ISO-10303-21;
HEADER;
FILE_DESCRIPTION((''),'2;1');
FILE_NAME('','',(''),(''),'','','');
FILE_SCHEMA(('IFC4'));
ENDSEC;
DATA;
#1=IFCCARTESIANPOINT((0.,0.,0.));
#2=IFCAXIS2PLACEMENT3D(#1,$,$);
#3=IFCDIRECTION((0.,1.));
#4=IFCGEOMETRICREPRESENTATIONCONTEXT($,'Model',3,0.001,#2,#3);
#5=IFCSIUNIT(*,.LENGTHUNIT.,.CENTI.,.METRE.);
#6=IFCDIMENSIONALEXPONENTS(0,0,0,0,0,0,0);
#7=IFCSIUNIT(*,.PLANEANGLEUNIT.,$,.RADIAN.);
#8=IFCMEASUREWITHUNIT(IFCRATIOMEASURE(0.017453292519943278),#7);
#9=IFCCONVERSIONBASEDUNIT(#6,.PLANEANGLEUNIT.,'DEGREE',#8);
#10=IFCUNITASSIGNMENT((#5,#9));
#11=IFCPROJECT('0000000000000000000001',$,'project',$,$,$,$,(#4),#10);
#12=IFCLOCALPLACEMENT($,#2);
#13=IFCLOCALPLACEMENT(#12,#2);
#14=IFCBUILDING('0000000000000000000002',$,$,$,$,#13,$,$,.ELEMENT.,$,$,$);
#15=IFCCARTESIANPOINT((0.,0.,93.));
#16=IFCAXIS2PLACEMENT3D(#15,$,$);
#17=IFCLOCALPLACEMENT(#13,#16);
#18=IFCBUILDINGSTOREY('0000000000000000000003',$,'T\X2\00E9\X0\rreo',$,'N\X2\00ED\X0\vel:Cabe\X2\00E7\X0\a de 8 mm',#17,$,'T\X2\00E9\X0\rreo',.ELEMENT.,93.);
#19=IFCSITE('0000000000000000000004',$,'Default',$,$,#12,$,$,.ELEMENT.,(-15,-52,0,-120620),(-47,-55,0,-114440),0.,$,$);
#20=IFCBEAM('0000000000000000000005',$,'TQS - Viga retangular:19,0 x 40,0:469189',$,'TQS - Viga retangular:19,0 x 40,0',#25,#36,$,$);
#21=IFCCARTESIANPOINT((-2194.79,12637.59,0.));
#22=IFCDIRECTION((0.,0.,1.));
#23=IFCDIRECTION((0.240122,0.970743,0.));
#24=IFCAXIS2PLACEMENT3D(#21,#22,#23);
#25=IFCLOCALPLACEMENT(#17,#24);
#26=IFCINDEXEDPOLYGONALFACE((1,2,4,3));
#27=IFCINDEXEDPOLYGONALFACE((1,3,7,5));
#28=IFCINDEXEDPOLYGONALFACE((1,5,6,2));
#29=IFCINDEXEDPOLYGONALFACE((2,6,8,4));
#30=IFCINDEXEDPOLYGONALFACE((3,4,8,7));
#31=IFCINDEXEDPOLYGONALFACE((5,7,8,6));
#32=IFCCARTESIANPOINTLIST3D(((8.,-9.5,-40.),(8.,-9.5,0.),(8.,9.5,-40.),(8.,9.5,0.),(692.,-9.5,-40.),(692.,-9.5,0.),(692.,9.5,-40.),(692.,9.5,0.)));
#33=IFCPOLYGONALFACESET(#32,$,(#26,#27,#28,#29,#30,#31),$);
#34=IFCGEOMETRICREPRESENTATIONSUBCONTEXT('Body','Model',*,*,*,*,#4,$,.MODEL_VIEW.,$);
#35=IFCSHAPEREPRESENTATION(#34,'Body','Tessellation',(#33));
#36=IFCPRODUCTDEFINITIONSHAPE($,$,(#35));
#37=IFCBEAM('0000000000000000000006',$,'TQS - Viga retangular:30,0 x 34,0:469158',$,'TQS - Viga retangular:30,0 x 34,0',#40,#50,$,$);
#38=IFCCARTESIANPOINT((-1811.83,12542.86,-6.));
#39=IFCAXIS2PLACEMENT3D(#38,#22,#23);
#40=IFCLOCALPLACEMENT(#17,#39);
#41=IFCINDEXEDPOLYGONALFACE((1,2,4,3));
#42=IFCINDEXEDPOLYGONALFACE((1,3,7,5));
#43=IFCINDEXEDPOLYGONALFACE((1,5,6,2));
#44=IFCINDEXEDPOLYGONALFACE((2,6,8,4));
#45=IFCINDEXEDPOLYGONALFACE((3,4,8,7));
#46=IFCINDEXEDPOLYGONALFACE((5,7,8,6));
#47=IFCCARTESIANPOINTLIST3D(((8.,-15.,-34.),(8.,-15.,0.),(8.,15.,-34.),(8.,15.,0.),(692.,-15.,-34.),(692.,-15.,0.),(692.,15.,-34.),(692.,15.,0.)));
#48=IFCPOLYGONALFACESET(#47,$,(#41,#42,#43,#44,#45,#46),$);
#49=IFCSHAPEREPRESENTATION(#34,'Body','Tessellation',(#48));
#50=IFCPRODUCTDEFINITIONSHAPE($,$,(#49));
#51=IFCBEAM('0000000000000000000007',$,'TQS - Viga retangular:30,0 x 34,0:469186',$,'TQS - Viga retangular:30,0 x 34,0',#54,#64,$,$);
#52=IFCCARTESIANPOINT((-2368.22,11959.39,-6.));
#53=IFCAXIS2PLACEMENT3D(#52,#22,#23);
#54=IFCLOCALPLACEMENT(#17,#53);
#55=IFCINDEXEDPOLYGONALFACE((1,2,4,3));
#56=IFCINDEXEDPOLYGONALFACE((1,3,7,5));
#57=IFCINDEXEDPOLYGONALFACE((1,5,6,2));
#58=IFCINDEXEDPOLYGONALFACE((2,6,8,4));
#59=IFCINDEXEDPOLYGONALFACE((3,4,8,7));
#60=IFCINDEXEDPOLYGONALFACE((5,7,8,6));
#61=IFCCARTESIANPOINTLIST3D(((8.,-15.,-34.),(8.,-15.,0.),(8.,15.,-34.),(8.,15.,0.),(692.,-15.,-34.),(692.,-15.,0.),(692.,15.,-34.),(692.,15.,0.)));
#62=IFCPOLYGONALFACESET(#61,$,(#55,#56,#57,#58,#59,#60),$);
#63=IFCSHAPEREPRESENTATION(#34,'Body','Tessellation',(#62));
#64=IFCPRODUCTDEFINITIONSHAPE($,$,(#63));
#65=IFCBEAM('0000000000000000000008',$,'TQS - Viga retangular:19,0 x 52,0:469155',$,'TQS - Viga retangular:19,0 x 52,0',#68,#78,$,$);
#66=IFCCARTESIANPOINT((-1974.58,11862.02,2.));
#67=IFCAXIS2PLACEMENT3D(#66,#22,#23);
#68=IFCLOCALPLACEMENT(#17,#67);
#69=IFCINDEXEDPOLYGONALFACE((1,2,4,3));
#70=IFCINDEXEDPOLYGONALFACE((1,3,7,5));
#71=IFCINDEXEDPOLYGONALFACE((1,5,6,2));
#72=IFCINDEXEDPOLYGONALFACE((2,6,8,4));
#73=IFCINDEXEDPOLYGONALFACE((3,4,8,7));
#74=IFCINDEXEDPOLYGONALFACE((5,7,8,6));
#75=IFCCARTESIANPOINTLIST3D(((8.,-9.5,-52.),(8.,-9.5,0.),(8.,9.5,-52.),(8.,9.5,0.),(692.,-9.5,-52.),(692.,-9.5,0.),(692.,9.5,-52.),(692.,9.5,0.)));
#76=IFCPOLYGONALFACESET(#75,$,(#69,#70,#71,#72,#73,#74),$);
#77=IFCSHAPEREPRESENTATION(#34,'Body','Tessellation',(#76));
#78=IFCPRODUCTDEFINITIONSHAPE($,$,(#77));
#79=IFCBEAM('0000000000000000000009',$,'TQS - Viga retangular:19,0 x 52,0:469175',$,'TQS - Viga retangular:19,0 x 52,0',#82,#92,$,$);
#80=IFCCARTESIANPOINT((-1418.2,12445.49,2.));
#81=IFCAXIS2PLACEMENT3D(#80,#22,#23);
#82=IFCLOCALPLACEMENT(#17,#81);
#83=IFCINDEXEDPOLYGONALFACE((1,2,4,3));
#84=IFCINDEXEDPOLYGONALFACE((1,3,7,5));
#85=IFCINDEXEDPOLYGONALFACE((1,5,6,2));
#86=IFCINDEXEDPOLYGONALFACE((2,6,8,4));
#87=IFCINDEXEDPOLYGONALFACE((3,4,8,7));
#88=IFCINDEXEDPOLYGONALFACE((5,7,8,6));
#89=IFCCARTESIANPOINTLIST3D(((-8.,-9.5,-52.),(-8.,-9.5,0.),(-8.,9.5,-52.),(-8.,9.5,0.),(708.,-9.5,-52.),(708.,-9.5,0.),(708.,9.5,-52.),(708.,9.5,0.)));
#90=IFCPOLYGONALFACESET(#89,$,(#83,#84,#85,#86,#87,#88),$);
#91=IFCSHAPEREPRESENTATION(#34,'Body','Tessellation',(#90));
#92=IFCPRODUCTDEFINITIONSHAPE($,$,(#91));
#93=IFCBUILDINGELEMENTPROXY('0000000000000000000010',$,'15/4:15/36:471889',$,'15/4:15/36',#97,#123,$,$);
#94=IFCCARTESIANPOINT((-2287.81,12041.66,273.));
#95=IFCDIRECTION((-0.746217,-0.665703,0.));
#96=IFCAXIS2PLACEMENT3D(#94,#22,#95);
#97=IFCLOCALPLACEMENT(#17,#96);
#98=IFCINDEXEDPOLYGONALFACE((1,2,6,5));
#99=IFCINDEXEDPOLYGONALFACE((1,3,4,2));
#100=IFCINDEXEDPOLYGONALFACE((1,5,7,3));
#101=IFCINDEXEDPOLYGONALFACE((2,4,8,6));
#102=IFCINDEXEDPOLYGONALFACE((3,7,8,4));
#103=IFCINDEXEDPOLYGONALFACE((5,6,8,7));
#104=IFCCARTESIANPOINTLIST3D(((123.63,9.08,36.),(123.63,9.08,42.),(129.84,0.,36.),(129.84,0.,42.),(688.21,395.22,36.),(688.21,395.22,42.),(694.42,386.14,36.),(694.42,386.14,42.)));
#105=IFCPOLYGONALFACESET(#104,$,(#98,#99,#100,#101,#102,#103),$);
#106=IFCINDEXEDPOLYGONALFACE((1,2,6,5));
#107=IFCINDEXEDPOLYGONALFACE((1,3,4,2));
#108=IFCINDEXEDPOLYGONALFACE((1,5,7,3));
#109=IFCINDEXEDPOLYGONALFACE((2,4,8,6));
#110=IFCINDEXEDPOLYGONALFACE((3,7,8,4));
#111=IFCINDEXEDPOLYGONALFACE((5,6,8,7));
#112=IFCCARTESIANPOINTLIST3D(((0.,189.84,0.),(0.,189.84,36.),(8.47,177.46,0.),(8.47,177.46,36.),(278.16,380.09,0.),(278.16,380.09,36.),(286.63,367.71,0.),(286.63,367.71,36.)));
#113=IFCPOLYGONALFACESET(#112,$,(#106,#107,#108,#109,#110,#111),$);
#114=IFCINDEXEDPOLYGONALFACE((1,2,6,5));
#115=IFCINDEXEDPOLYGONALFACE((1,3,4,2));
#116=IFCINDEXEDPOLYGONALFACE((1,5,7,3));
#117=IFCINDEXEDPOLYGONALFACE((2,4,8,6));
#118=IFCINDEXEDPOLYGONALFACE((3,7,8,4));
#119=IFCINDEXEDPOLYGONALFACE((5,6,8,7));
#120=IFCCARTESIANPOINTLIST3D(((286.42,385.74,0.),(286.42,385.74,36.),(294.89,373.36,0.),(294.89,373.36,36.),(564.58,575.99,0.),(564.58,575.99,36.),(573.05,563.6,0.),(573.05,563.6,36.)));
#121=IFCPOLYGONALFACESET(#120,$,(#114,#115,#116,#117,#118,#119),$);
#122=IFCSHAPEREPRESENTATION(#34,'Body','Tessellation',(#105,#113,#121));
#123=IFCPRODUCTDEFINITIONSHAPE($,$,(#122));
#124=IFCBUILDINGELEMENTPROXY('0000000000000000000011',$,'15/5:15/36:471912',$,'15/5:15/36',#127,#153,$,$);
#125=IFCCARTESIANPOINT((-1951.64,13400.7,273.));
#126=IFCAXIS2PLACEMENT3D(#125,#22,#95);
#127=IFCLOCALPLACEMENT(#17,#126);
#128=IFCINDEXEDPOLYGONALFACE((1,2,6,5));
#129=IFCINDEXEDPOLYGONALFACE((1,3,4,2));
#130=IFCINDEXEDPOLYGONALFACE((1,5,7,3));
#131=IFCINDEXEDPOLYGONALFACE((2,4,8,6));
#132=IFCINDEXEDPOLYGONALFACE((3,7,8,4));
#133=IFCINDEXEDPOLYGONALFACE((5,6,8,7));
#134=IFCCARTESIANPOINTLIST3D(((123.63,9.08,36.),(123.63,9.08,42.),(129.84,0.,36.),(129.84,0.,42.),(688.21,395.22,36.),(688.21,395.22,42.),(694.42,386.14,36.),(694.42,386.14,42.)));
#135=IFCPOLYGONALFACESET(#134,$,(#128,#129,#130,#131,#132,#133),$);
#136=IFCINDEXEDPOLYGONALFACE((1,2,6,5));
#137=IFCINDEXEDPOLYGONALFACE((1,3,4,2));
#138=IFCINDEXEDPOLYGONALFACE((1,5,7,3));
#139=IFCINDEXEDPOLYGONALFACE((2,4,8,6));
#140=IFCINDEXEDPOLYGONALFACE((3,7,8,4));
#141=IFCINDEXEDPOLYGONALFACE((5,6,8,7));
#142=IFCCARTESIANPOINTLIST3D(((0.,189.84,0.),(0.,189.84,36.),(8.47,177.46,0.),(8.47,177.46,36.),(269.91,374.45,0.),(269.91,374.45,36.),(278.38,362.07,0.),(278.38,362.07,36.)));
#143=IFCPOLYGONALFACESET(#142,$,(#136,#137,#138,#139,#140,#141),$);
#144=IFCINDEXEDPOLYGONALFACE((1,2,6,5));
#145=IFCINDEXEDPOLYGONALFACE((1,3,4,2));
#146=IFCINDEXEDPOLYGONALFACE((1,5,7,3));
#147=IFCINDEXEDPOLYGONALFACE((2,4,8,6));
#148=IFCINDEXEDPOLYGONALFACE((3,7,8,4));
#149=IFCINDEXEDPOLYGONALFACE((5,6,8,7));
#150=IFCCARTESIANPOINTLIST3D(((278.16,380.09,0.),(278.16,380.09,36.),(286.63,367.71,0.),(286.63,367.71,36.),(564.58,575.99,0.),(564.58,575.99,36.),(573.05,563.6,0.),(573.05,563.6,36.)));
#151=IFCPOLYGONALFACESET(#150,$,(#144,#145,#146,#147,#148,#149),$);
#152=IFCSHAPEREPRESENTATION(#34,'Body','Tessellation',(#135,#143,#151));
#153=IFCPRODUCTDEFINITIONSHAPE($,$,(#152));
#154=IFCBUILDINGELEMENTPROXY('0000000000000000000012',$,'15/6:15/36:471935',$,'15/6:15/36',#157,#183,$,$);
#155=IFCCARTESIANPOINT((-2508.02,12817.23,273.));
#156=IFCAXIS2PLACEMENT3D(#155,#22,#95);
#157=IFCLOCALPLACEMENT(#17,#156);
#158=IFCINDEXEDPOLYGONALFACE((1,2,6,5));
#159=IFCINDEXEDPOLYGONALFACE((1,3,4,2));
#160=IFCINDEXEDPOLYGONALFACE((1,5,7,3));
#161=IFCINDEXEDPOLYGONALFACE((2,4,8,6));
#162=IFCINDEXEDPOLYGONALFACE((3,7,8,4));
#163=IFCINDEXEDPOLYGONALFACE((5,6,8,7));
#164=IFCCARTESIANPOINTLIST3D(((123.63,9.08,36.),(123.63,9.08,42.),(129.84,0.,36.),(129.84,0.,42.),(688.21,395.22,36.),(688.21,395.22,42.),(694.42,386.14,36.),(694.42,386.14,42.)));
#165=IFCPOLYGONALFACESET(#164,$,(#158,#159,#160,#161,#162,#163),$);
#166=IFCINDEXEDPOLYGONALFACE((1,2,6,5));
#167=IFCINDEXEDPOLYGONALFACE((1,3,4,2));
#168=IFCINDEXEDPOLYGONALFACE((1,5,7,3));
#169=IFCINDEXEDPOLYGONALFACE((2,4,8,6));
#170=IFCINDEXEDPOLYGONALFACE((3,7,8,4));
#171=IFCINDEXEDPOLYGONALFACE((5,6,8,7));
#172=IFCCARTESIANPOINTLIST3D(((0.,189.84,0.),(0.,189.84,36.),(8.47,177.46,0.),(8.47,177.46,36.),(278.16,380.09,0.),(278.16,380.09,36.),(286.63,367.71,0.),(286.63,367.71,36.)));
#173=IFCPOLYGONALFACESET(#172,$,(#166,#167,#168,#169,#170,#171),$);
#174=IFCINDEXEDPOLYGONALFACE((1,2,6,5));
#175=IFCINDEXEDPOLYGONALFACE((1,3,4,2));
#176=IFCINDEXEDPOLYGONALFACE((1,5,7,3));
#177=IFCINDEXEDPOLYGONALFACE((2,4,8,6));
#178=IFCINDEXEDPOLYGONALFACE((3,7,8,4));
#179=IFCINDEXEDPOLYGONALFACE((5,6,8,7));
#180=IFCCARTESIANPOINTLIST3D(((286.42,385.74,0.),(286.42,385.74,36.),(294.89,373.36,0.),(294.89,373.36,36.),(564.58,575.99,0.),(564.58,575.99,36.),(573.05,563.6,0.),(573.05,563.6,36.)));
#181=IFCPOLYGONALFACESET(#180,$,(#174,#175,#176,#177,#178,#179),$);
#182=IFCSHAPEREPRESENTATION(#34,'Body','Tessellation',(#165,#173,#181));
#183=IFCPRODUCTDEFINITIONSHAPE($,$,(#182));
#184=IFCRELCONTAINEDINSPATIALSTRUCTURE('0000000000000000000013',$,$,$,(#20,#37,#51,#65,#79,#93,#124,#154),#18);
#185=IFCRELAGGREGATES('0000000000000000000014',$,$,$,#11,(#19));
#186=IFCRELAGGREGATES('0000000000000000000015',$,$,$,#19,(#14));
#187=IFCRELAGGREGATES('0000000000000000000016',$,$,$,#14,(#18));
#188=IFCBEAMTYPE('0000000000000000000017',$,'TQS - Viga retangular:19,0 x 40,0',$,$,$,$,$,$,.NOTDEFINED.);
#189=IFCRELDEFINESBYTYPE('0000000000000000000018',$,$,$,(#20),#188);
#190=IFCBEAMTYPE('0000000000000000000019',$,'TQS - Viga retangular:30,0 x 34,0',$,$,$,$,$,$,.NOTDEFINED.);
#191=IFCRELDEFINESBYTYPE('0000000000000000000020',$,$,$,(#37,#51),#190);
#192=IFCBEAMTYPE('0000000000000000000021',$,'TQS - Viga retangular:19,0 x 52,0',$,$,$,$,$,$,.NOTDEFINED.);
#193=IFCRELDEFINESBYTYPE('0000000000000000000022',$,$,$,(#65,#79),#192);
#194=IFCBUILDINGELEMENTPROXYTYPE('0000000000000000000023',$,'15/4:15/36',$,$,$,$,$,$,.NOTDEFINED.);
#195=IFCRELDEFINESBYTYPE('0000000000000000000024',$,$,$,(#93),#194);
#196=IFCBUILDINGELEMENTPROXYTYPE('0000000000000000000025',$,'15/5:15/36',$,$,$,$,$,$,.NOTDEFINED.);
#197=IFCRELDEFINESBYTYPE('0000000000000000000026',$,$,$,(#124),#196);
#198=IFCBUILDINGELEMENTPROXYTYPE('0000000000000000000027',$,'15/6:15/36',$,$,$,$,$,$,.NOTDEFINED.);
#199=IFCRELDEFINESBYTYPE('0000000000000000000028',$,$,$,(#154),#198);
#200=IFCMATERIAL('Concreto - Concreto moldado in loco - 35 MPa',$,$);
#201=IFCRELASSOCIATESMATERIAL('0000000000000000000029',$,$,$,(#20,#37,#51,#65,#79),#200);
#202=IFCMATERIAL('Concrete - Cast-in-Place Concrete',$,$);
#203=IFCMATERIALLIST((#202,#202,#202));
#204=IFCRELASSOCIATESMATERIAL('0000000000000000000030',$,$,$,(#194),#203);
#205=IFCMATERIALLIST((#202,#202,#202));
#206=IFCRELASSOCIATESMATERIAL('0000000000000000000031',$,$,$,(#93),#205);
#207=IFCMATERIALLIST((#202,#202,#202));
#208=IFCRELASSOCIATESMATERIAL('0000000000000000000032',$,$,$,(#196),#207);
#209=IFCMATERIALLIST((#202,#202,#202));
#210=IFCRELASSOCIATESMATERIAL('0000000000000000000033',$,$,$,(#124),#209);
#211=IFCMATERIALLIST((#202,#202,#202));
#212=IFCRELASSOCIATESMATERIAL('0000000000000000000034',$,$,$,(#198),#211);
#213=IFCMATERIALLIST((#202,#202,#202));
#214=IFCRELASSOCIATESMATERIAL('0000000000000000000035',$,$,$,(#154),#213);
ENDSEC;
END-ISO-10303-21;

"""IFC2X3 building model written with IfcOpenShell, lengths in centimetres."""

from ifc_helpers import new_model, entity, si_unit, converted_unit, direction, frame, frame_2d, origin, origin_2d_with_axis, place, context, subcontext, project, spatial, rectangle, extrude, source, transform, mapped, material, material_list, type_object, type_shapes, element, save


model = new_model("IFC2X3")

# Units and contexts
model_context = context("Model", 3, precision=0.001, world=origin(), true_north=direction((0.0, 1.0)))
body_context = subcontext(model_context, "Body", "Model", "MODEL_VIEW")
ifc_project = project(units=[si_unit("LENGTHUNIT", "METRE", prefix="CENTI"), converted_unit("PLANEANGLEUNIT", "DEGREE", entity("IfcRatioMeasure", 0.017453292519943278), si_unit("PLANEANGLEUNIT", "RADIAN"), dimensions=[0, 0, 0, 0, 0, 0, 0])], contexts=[model_context])

# Site, building, storey
site_placement = place(None, origin())
site = spatial("IfcSite", under=ifc_project, at=site_placement, Name="Default", CompositionType="ELEMENT", RefLatitude=(-15, -52, 0, -120620), RefLongitude=(-47, -55, 0, -114440), RefElevation=0.0)
building_placement = place(site_placement, origin())
building = spatial("IfcBuilding", under=site, at=building_placement, CompositionType="ELEMENT")
storey_placement = place(building_placement, frame((0.0, 0.0, 93.0)))
storey = spatial("IfcBuildingStorey", under=building, at=storey_placement, Name="Térreo", ObjectType="Nível:Cabeça de 8 mm", LongName="Térreo", CompositionType="ELEMENT", Elevation=93.0)

# Beams
ifc_material_1 = material(Name="Concreto - Concreto moldado in loco - 35 MPa")
beam_type_1 = type_object("IfcBeamType", Name="TQS - Viga retangular:19,0 x 40,0", PredefinedType="NOTDEFINED")
beam_1_placement = place(storey_placement, frame((-2194.79, 12637.59, 0.0), z_axis=(0.0, 0.0, 1.0), x_axis=(0.240122, 0.970743, 0.0)))
element("IfcBeam", 1, at=beam_1_placement, inside=storey, type_object=beam_type_1, material=ifc_material_1, Name="TQS - Viga retangular:19,0 x 40,0:469189", ObjectType="TQS - Viga retangular:19,0 x 40,0", context=body_context, shape_type="SweptSolid", body=[
    extrude(rectangle(XDim=40.0, YDim=19.0, at=frame_2d((0.0, 0.0), x_axis=(1.0, 0.0))), frame((8.0, 0.0, -20.0), z_axis=(1.0, 0.0, 0.0), x_axis=(0.0, 0.0, -1.0)), (0.0, 0.0, 1.0), 684.0),
])
beam_type_2 = type_object("IfcBeamType", Name="TQS - Viga retangular:30,0 x 34,0", PredefinedType="NOTDEFINED")
beam_2_placement = place(storey_placement, frame((-1811.83, 12542.86, -6.0), z_axis=(0.0, 0.0, 1.0), x_axis=(0.240122, 0.970743, 0.0)))
element("IfcBeam", 2, at=beam_2_placement, inside=storey, type_object=beam_type_2, material=ifc_material_1, Name="TQS - Viga retangular:30,0 x 34,0:469158", ObjectType="TQS - Viga retangular:30,0 x 34,0", context=body_context, shape_type="SweptSolid", body=[
    extrude(rectangle(XDim=34.0, YDim=30.0, at=frame_2d((0.0, 0.0), x_axis=(1.0, 0.0))), frame((8.0, 0.0, -17.0), z_axis=(1.0, 0.0, 0.0), x_axis=(0.0, 0.0, -1.0)), (0.0, 0.0, 1.0), 684.0),
])
beam_3_placement = place(storey_placement, frame((-2368.22, 11959.39, -6.0), z_axis=(0.0, 0.0, 1.0), x_axis=(0.240122, 0.970743, 0.0)))
element("IfcBeam", 3, at=beam_3_placement, inside=storey, type_object=beam_type_2, material=ifc_material_1, Name="TQS - Viga retangular:30,0 x 34,0:469186", ObjectType="TQS - Viga retangular:30,0 x 34,0", context=body_context, shape_type="SweptSolid", body=[
    extrude(rectangle(XDim=34.0, YDim=30.0, at=frame_2d((0.0, 0.0), x_axis=(1.0, 0.0))), frame((8.0, 0.0, -17.0), z_axis=(1.0, 0.0, 0.0), x_axis=(0.0, 0.0, -1.0)), (0.0, 0.0, 1.0), 684.0),
])
beam_type_3 = type_object("IfcBeamType", Name="TQS - Viga retangular:19,0 x 52,0", PredefinedType="NOTDEFINED")
beam_4_placement = place(storey_placement, frame((-1974.58, 11862.02, 2.0), z_axis=(0.0, 0.0, 1.0), x_axis=(0.240122, 0.970743, 0.0)))
element("IfcBeam", 4, at=beam_4_placement, inside=storey, type_object=beam_type_3, material=ifc_material_1, Name="TQS - Viga retangular:19,0 x 52,0:469155", ObjectType="TQS - Viga retangular:19,0 x 52,0", context=body_context, shape_type="SweptSolid", body=[
    extrude(rectangle(XDim=52.0, YDim=19.0, at=origin_2d_with_axis()), frame((8.0, 0.0, -26.0), z_axis=(1.0, 0.0, 0.0), x_axis=(0.0, 0.0, -1.0)), (0.0, 0.0, 1.0), 684.0),
])
beam_5_placement = place(storey_placement, frame((-1418.2, 12445.49, 2.0), z_axis=(0.0, 0.0, 1.0), x_axis=(0.240122, 0.970743, 0.0)))
element("IfcBeam", 5, at=beam_5_placement, inside=storey, type_object=beam_type_3, material=ifc_material_1, Name="TQS - Viga retangular:19,0 x 52,0:469175", ObjectType="TQS - Viga retangular:19,0 x 52,0", context=body_context, shape_type="SweptSolid", body=[
    extrude(rectangle(XDim=52.0, YDim=19.0, at=frame_2d((0.0, 0.0), x_axis=(1.0, 0.0))), frame((-8.0, 0.0, -26.0), z_axis=(1.0, 0.0, 0.0), x_axis=(0.0, 0.0, -1.0)), (0.0, 0.0, 1.0), 716.0),
])

# Building element proxies
ifc_material_2 = material(Name="Concrete - Cast-in-Place Concrete")
ifc_material_list_1 = material_list([ifc_material_2, ifc_material_2, ifc_material_2])
ifc_material_list_2 = material_list([ifc_material_2, ifc_material_2, ifc_material_2])
building_element_proxy_type_1 = type_object("IfcBuildingElementProxyType", Name="15/4:15/36", PredefinedType="NOTDEFINED", material=ifc_material_list_2)
shared_shape_1 = source(origin(), body_context, "Body", "SweptSolid", [
    extrude(rectangle(XDim=11.0, YDim=684.0, at=frame_2d((0.0, 0.0), x_axis=(1.0, 0.0))), frame((409.03, 197.61, 36.0), z_axis=(0.0, 0.0, 1.0), x_axis=(-0.564535, 0.825409, 0.0)), (0.0, 0.0, 1.0), 6.0),
    extrude(rectangle(XDim=337.0, YDim=15.0, at=frame_2d((0.0, 0.0), x_axis=(1.0, 0.0))), frame((143.32, 278.78, 0.0), z_axis=(0.0, 0.0, 1.0), x_axis=(0.825409, 0.564535, 0.0)), (0.0, 0.0, 1.0), 36.0),
    extrude(rectangle(XDim=337.0, YDim=15.0, at=frame_2d((0.0, 0.0), x_axis=(1.0, 0.0))), frame((429.73, 474.67, 0.0), z_axis=(0.0, 0.0, 1.0), x_axis=(0.825409, 0.564535, 0.0)), (0.0, 0.0, 1.0), 36.0),
])
type_shapes(building_element_proxy_type_1, [shared_shape_1])
proxy_1_placement = place(storey_placement, frame((-2287.81, 12041.66, 273.0), z_axis=(0.0, 0.0, 1.0), x_axis=(-0.746217, -0.665703, 0.0)))
element("IfcBuildingElementProxy", 6, at=proxy_1_placement, inside=storey, type_object=building_element_proxy_type_1, material=ifc_material_list_1, Name="15/4:15/36:471889", ObjectType="15/4:15/36", context=body_context, shape_type="MappedRepresentation", body=[
    mapped(shared_shape_1, transform((0.0, 0.0, 0.0), scale=1.0)),
])
ifc_material_list_3 = material_list([ifc_material_2, ifc_material_2, ifc_material_2])
ifc_material_list_4 = material_list([ifc_material_2, ifc_material_2, ifc_material_2])
building_element_proxy_type_2 = type_object("IfcBuildingElementProxyType", Name="15/5:15/36", PredefinedType="NOTDEFINED", material=ifc_material_list_4)
shared_shape_2 = source(origin(), body_context, "Body", "SweptSolid", [
    extrude(rectangle(XDim=11.0, YDim=684.0, at=frame_2d((0.0, 0.0), x_axis=(1.0, 0.0))), frame((409.03, 197.61, 36.0), z_axis=(0.0, 0.0, 1.0), x_axis=(-0.564535, 0.825409, 0.0)), (0.0, 0.0, 1.0), 6.0),
    extrude(rectangle(XDim=327.0, YDim=15.0, at=frame_2d((0.0, 0.0), x_axis=(1.0, 0.0))), frame((139.19, 275.96, 0.0), z_axis=(0.0, 0.0, 1.0), x_axis=(0.825409, 0.564535, 0.0)), (0.0, 0.0, 1.0), 36.0),
    extrude(rectangle(XDim=347.0, YDim=15.0, at=frame_2d((0.0, 0.0), x_axis=(1.0, 0.0))), frame((425.61, 471.85, 0.0), z_axis=(0.0, 0.0, 1.0), x_axis=(0.825409, 0.564535, 0.0)), (0.0, 0.0, 1.0), 36.0),
])
type_shapes(building_element_proxy_type_2, [shared_shape_2])
proxy_2_placement = place(storey_placement, frame((-1951.64, 13400.7, 273.0), z_axis=(0.0, 0.0, 1.0), x_axis=(-0.746217, -0.665703, 0.0)))
element("IfcBuildingElementProxy", 7, at=proxy_2_placement, inside=storey, type_object=building_element_proxy_type_2, material=ifc_material_list_3, Name="15/5:15/36:471912", ObjectType="15/5:15/36", context=body_context, shape_type="MappedRepresentation", body=[
    mapped(shared_shape_2, transform((0.0, 0.0, 0.0), scale=1.0)),
])
ifc_material_list_5 = material_list([ifc_material_2, ifc_material_2, ifc_material_2])
ifc_material_list_6 = material_list([ifc_material_2, ifc_material_2, ifc_material_2])
building_element_proxy_type_3 = type_object("IfcBuildingElementProxyType", Name="15/6:15/36", PredefinedType="NOTDEFINED", material=ifc_material_list_6)
shared_shape_3 = source(origin(), body_context, "Body", "SweptSolid", [
    extrude(rectangle(XDim=11.0, YDim=684.0, at=frame_2d((0.0, 0.0), x_axis=(1.0, 0.0))), frame((409.03, 197.61, 36.0), z_axis=(0.0, 0.0, 1.0), x_axis=(-0.564535, 0.825409, 0.0)), (0.0, 0.0, 1.0), 6.0),
    extrude(rectangle(XDim=337.0, YDim=15.0, at=frame_2d((0.0, 0.0), x_axis=(1.0, 0.0))), frame((143.32, 278.78, 0.0), z_axis=(0.0, 0.0, 1.0), x_axis=(0.825409, 0.564535, 0.0)), (0.0, 0.0, 1.0), 36.0),
    extrude(rectangle(XDim=337.0, YDim=15.0, at=frame_2d((0.0, 0.0), x_axis=(1.0, 0.0))), frame((429.73, 474.67, 0.0), z_axis=(0.0, 0.0, 1.0), x_axis=(0.825409, 0.564535, 0.0)), (0.0, 0.0, 1.0), 36.0),
])
type_shapes(building_element_proxy_type_3, [shared_shape_3])
proxy_3_placement = place(storey_placement, frame((-2508.02, 12817.23, 273.0), z_axis=(0.0, 0.0, 1.0), x_axis=(-0.746217, -0.665703, 0.0)))
element("IfcBuildingElementProxy", 8, at=proxy_3_placement, inside=storey, type_object=building_element_proxy_type_3, material=ifc_material_list_5, Name="15/6:15/36:471935", ObjectType="15/6:15/36", context=body_context, shape_type="MappedRepresentation", body=[
    mapped(shared_shape_3, transform((0.0, 0.0, 0.0), scale=1.0)),
])

save(model, "model.ifc")
